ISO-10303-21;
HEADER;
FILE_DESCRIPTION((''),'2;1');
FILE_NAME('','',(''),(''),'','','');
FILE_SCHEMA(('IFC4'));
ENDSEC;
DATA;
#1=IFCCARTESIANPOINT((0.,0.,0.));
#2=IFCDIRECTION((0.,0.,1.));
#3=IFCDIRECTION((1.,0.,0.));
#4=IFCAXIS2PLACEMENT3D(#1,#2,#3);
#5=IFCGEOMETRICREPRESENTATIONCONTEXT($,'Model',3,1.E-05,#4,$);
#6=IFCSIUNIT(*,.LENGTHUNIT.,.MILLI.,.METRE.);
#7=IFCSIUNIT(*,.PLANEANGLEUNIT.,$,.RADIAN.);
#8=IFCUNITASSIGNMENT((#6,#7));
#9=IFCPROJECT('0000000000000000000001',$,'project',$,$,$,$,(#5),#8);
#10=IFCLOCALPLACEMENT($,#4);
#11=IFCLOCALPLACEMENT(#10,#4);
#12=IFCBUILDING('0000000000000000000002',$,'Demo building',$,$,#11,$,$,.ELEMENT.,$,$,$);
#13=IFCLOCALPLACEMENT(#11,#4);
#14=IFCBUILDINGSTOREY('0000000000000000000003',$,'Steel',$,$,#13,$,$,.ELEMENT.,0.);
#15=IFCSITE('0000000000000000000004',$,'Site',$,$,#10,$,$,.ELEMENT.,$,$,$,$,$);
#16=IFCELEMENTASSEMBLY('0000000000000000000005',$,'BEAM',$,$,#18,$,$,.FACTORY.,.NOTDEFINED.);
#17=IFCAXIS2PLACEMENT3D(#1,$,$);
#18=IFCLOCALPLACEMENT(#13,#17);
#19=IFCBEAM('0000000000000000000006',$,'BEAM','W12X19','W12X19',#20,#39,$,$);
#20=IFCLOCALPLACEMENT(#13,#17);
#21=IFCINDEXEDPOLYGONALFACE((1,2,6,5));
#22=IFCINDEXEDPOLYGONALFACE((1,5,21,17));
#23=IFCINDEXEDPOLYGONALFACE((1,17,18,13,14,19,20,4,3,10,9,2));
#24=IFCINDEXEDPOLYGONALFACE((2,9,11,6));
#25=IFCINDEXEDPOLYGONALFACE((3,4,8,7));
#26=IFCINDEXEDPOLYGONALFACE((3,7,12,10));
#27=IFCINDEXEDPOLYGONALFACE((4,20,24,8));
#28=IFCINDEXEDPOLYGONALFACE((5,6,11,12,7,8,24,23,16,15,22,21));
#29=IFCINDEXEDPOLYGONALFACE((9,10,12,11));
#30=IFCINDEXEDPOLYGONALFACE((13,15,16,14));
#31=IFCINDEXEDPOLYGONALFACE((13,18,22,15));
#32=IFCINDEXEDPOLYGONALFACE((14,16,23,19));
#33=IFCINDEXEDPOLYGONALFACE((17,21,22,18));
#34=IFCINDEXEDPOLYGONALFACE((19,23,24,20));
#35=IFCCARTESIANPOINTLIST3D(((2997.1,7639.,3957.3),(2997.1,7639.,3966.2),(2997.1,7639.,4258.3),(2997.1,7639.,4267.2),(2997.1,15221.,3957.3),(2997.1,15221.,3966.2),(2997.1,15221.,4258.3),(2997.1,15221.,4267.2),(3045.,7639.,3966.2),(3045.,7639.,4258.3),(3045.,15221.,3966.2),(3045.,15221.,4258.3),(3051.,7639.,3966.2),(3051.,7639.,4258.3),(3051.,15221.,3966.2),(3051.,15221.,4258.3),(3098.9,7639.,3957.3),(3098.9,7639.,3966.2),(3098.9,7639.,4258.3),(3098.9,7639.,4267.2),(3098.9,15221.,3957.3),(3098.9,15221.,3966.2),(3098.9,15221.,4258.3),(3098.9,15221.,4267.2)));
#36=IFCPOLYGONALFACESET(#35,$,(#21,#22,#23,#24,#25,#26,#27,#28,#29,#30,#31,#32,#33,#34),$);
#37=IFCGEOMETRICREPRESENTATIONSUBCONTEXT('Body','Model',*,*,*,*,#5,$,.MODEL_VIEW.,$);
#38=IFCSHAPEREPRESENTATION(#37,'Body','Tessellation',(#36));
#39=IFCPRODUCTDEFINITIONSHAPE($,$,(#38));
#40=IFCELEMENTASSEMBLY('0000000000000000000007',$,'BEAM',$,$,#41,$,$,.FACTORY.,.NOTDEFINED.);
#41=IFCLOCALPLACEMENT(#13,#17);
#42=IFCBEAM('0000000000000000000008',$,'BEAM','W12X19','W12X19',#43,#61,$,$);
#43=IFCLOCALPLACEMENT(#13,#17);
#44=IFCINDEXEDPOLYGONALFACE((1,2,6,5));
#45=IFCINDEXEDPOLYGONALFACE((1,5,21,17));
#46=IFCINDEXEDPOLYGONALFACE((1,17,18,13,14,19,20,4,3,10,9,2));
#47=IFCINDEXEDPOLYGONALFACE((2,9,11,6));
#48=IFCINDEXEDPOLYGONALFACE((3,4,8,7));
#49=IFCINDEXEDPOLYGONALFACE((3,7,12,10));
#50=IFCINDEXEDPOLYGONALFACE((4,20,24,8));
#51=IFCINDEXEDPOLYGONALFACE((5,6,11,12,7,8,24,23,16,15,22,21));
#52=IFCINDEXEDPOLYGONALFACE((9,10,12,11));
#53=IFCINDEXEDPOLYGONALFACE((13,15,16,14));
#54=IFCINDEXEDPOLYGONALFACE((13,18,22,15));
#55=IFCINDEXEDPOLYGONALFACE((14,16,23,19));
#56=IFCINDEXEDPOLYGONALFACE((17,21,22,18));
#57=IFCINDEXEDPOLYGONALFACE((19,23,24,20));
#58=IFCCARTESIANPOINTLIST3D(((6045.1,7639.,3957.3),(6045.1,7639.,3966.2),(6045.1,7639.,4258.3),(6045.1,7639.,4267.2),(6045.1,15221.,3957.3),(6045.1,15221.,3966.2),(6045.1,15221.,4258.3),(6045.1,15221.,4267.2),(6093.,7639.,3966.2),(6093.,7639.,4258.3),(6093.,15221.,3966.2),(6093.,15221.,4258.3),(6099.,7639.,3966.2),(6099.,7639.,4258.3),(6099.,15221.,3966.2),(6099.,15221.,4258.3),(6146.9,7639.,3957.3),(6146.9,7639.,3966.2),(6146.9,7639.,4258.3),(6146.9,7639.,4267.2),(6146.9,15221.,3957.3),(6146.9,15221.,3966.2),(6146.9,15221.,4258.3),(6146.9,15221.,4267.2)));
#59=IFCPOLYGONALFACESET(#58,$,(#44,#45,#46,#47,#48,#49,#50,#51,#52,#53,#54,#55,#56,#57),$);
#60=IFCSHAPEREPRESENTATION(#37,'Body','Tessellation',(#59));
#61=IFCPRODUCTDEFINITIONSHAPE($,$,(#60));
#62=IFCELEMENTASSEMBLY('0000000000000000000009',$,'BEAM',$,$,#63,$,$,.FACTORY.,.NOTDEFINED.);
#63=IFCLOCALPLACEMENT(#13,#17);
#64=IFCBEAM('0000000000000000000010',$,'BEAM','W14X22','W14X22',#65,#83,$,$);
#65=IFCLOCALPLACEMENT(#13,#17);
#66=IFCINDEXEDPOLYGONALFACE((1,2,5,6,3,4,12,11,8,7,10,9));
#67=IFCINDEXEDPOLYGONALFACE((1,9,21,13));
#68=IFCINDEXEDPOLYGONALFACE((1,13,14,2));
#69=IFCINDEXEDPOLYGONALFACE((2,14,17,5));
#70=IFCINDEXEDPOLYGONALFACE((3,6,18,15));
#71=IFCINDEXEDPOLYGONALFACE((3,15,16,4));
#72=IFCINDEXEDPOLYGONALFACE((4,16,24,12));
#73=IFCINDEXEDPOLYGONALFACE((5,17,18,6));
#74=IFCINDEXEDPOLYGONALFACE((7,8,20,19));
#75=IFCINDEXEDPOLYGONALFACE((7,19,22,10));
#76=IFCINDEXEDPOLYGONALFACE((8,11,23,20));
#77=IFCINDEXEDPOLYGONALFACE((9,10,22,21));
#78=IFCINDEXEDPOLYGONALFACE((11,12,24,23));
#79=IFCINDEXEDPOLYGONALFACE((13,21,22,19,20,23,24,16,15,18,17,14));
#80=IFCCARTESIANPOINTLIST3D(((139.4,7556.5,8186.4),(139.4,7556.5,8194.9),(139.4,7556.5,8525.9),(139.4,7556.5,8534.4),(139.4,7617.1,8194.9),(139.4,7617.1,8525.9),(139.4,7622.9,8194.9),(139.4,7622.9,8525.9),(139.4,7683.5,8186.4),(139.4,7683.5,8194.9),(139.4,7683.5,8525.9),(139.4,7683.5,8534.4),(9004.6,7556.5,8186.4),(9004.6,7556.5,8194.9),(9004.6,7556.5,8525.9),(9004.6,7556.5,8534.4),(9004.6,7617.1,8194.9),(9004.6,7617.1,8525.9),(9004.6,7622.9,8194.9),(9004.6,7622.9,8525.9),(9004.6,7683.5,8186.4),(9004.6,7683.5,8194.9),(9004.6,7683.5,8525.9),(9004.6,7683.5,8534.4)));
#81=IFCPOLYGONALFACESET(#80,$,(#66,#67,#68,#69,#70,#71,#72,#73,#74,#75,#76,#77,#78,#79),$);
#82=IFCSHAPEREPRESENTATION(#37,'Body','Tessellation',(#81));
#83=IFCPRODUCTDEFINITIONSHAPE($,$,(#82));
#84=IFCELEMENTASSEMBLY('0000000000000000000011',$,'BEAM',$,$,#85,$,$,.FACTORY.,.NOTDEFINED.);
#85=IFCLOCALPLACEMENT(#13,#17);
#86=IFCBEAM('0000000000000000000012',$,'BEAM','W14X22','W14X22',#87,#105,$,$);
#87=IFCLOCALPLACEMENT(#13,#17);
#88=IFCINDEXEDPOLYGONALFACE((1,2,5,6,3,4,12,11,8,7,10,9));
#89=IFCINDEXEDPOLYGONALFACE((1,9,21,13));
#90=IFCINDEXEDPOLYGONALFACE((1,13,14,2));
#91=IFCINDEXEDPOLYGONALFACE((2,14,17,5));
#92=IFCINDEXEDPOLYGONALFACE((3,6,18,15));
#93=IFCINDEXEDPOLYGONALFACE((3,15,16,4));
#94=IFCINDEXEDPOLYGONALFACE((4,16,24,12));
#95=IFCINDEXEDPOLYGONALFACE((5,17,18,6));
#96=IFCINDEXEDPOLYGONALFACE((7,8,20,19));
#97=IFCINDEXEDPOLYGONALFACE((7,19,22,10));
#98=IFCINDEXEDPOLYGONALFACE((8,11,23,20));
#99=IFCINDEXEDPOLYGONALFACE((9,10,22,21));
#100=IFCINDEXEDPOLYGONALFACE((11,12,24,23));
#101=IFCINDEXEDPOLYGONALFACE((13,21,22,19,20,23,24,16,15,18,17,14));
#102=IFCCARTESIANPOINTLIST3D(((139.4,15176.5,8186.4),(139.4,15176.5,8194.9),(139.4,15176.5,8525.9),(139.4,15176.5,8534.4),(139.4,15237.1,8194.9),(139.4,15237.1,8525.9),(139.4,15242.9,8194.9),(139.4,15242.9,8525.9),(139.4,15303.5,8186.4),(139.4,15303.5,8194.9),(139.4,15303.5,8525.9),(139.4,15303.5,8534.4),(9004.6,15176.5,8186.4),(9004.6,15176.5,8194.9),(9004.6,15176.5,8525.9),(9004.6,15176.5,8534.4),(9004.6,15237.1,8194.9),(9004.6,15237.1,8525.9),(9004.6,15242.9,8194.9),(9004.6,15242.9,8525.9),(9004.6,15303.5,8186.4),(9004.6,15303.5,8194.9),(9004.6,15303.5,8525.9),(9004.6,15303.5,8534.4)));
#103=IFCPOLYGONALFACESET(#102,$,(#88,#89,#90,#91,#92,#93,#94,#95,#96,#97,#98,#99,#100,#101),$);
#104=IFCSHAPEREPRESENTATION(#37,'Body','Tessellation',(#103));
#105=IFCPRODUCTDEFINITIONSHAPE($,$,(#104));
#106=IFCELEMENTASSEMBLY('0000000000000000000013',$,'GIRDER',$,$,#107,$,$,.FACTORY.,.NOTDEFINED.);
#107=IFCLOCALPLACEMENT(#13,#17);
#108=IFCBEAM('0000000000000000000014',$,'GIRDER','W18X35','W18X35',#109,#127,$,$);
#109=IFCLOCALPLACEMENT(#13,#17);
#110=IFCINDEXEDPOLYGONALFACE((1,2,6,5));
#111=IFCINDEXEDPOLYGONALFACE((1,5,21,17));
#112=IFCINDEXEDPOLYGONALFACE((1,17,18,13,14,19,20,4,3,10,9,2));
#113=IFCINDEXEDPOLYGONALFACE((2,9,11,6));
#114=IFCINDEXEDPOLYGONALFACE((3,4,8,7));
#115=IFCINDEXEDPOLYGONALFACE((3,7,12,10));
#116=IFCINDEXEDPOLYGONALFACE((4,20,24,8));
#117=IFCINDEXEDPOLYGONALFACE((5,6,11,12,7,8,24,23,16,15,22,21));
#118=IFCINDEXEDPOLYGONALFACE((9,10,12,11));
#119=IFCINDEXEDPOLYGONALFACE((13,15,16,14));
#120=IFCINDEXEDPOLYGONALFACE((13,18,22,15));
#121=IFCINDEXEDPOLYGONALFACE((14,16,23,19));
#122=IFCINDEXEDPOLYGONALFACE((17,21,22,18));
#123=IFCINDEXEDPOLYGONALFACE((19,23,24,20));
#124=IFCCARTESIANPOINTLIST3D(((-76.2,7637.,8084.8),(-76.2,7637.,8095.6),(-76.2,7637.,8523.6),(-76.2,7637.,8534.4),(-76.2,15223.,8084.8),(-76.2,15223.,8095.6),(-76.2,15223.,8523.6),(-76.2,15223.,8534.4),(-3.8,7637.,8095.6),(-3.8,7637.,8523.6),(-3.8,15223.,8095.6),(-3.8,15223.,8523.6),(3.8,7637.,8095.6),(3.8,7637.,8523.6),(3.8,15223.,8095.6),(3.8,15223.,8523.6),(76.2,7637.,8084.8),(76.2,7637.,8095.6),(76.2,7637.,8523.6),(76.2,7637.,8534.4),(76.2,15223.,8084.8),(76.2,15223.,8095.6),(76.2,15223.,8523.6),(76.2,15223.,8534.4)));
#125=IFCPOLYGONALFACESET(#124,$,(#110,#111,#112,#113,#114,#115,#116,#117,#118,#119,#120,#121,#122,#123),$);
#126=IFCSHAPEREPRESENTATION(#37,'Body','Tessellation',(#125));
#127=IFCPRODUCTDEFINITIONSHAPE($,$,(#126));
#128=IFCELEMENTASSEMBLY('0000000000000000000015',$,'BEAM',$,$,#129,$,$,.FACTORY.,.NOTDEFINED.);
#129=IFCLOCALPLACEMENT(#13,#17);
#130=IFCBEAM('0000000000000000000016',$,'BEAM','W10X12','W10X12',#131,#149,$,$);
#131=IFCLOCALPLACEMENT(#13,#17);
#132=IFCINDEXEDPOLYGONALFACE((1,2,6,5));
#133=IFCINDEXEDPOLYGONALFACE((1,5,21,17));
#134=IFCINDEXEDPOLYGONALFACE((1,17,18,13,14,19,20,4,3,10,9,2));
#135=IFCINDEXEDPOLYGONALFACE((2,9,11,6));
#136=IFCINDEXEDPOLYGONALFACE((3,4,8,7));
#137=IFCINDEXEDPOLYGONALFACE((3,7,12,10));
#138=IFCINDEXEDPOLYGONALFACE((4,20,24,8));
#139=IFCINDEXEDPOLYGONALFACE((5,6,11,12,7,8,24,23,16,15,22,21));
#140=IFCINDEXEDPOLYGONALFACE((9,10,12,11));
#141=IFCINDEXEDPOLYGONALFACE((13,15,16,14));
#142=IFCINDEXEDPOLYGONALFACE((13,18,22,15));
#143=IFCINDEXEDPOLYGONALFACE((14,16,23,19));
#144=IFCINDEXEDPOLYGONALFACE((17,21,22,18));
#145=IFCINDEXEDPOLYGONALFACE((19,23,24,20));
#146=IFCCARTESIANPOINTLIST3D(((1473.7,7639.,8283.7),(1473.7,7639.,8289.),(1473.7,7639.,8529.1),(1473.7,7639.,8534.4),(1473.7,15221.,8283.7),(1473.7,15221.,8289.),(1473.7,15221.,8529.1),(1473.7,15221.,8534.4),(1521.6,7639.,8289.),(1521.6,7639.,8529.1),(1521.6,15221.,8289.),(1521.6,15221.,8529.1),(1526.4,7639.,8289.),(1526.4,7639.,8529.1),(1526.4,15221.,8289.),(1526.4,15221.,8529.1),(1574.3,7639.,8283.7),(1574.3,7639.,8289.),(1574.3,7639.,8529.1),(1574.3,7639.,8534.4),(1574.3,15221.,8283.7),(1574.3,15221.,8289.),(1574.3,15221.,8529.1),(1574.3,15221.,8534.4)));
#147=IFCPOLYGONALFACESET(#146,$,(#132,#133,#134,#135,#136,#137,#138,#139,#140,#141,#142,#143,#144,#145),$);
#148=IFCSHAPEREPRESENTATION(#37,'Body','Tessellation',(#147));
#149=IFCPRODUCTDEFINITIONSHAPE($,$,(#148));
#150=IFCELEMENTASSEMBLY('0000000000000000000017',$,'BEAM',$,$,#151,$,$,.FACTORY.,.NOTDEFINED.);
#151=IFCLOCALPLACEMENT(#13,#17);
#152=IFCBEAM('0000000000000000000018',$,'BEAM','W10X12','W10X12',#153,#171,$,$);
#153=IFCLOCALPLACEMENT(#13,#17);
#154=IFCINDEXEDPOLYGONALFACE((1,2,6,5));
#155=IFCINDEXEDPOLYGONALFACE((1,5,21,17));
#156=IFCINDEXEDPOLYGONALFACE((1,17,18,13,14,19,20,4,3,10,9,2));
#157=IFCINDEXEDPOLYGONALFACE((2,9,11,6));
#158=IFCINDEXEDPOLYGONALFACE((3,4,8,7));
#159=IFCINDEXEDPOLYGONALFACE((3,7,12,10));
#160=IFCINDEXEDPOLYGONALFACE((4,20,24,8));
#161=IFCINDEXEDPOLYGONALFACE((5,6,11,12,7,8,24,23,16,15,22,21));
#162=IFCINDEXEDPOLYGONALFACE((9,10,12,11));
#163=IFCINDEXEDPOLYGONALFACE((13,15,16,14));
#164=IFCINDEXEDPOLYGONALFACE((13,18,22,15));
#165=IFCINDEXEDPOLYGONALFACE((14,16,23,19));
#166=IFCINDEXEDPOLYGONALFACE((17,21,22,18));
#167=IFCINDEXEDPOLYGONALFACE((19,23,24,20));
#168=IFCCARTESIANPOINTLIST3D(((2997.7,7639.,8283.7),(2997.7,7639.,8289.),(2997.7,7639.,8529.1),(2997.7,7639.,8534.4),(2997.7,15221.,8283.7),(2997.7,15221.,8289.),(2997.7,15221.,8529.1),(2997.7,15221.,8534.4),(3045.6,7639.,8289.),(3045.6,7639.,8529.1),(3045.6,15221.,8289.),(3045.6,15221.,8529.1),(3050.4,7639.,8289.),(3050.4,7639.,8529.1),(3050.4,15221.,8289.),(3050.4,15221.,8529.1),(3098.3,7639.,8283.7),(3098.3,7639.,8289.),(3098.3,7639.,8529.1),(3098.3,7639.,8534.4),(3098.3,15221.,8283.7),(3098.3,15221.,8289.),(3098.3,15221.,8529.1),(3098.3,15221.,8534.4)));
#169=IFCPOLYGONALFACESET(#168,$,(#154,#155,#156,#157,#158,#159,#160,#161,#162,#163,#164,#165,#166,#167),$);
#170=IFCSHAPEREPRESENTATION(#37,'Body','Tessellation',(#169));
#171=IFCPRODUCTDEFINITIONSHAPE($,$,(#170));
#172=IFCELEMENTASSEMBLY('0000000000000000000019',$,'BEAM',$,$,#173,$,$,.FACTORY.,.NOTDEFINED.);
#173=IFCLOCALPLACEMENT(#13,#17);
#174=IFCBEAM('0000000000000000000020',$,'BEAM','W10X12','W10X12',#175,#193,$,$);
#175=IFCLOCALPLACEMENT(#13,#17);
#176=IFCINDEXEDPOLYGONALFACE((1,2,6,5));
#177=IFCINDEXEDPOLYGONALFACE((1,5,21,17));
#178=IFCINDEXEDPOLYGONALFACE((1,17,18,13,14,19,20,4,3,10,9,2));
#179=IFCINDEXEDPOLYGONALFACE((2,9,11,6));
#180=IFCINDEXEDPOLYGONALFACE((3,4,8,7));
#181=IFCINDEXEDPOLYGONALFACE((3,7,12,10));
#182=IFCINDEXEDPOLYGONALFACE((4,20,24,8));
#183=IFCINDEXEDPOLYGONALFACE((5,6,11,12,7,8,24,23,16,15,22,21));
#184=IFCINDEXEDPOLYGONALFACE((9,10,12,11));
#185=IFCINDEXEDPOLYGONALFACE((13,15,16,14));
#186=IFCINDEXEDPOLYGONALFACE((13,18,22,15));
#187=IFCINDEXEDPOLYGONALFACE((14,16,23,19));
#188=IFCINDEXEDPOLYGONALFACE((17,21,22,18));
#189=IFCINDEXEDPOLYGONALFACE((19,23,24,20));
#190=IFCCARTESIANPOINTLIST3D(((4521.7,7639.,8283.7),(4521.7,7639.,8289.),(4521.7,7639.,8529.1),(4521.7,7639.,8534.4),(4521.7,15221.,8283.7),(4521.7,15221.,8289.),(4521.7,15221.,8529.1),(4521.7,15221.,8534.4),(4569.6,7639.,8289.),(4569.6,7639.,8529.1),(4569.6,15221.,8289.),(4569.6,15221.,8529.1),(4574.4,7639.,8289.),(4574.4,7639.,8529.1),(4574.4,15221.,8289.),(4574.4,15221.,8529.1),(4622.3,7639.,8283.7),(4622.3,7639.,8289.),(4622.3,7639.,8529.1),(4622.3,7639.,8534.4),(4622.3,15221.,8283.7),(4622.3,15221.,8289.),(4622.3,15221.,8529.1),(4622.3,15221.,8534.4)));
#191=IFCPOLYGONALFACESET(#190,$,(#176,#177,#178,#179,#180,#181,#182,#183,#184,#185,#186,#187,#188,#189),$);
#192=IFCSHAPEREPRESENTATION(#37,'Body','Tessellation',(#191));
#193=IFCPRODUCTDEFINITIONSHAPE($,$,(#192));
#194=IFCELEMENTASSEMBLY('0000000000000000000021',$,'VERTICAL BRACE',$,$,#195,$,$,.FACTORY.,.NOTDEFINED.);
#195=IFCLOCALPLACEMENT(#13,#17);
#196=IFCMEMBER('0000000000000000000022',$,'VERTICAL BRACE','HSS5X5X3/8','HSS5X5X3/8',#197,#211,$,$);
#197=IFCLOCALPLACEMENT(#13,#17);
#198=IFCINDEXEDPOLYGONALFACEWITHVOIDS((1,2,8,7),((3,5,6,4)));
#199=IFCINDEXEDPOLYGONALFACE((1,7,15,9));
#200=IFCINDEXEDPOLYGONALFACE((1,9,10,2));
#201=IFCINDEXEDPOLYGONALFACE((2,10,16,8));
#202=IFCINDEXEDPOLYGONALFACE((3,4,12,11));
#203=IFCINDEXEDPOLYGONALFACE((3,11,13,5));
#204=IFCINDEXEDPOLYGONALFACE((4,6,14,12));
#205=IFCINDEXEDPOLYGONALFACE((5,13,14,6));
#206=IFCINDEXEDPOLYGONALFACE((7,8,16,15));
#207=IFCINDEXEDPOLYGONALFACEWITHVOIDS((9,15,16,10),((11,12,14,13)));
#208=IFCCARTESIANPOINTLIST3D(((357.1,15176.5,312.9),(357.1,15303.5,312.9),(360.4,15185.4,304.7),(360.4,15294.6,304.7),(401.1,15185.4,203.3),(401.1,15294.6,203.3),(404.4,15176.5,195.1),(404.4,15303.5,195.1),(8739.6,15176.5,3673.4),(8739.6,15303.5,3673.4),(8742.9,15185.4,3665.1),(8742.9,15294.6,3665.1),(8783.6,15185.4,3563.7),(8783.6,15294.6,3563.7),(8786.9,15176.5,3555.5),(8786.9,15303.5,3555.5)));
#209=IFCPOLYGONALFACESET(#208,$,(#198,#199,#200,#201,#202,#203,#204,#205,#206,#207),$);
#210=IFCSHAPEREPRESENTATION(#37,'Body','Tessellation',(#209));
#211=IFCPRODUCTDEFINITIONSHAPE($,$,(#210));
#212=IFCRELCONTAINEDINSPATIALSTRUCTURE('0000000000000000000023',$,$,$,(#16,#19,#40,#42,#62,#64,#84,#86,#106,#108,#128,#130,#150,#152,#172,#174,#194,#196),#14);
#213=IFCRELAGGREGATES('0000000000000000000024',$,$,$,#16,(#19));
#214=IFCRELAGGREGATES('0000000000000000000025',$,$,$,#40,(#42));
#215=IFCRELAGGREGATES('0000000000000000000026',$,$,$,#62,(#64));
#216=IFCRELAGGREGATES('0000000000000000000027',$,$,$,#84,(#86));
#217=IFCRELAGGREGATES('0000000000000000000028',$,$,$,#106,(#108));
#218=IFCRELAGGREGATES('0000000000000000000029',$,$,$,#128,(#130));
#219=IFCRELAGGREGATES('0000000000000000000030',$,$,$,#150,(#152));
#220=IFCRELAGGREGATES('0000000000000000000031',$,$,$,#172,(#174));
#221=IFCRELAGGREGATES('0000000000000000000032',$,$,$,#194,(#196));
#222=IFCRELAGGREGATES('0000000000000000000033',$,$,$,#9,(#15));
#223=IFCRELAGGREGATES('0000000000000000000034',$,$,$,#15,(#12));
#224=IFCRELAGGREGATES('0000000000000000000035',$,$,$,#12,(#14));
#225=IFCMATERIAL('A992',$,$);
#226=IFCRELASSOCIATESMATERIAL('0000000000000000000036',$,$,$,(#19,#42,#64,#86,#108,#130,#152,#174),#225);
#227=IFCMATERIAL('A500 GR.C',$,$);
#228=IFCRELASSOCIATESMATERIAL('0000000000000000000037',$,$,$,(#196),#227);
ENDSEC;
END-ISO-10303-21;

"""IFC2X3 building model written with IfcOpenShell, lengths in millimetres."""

from ifc_helpers import new_model, si_unit, frame, origin, origin_with_axes, origin_2d, place, context, subcontext, project, spatial, hollow_rectangle, i_section, extrude, material, element, aggregate, save


model = new_model("IFC2X3")

# Units and contexts
model_context = context("Model", 3, precision=1e-05, world=origin_with_axes())
body_context = subcontext(model_context, "Body", "Model", "MODEL_VIEW")
ifc_project = project(units=[si_unit("LENGTHUNIT", "METRE", prefix="MILLI"), si_unit("PLANEANGLEUNIT", "RADIAN")], contexts=[model_context])

# Site, building, storey
site_placement = place(None, origin_with_axes())
site = spatial("IfcSite", under=ifc_project, at=site_placement, Name="Site", CompositionType="ELEMENT")
building_placement = place(site_placement, origin_with_axes())
building = spatial("IfcBuilding", under=site, at=building_placement, Name="Demo building", CompositionType="ELEMENT")
placement = place(building_placement, origin_with_axes())
storey = spatial("IfcBuildingStorey", under=building, at=placement, Name="Steel", CompositionType="ELEMENT", Elevation=0.0)

# Shared definitions
ifc_material_1 = material(Name="A992")

# Element assemblies, beams
assembly_1 = element("IfcElementAssembly", 1, at=placement, inside=storey, Name="BEAM", AssemblyPlace="FACTORY", PredefinedType="NOTDEFINED")
beam_1_placement = place(placement, frame((3048.0, 7639.1, 4112.3), z_axis=(0.0, 1.0, 0.0), x_axis=(-1.0, 0.0, 0.0)))
beam_1 = element("IfcBeam", 2, at=beam_1_placement, inside=storey, material=ifc_material_1, Name="BEAM", Description="W12X19", ObjectType="W12X19", context=body_context, shape_type="SweptSolid", body=[
    extrude(i_section(OverallWidth=101.9, OverallDepth=309.9, WebThickness=6.0, FlangeThickness=8.9, at=origin_2d()), origin(), (0.0, 0.0, 1.0), 7581.9),
])
aggregate(assembly_1, [beam_1])
assembly_2 = element("IfcElementAssembly", 3, at=placement, inside=storey, Name="BEAM", AssemblyPlace="FACTORY", PredefinedType="NOTDEFINED")
beam_2_placement = place(placement, frame((6096.0, 7639.1, 4112.3), z_axis=(0.0, 1.0, 0.0), x_axis=(-1.0, 0.0, 0.0)))
beam_2 = element("IfcBeam", 4, at=beam_2_placement, inside=storey, material=ifc_material_1, Name="BEAM", Description="W12X19", ObjectType="W12X19", context=body_context, shape_type="SweptSolid", body=[
    extrude(i_section(OverallWidth=101.9, OverallDepth=309.9, WebThickness=6.0, FlangeThickness=8.9, at=origin_2d()), origin(), (0.0, 0.0, 1.0), 7581.9),
])
aggregate(assembly_2, [beam_2])
assembly_3 = element("IfcElementAssembly", 5, at=placement, inside=storey, Name="BEAM", AssemblyPlace="FACTORY", PredefinedType="NOTDEFINED")
beam_3_placement = place(placement, frame((139.4, 7620.0, 8360.4), z_axis=(1.0, 0.0, 0.0), x_axis=(0.0, 1.0, 0.0)))
beam_3 = element("IfcBeam", 6, at=beam_3_placement, inside=storey, material=ifc_material_1, Name="BEAM", Description="W14X22", ObjectType="W14X22", context=body_context, shape_type="SweptSolid", body=[
    extrude(i_section(OverallWidth=127.0, OverallDepth=348.0, WebThickness=5.8, FlangeThickness=8.5, at=origin_2d()), origin(), (0.0, 0.0, 1.0), 8865.1),
])
aggregate(assembly_3, [beam_3])
assembly_4 = element("IfcElementAssembly", 7, at=placement, inside=storey, Name="BEAM", AssemblyPlace="FACTORY", PredefinedType="NOTDEFINED")
beam_4_placement = place(placement, frame((139.4, 15240.0, 8360.4), z_axis=(1.0, 0.0, 0.0), x_axis=(0.0, 1.0, 0.0)))
beam_4 = element("IfcBeam", 8, at=beam_4_placement, inside=storey, material=ifc_material_1, Name="BEAM", Description="W14X22", ObjectType="W14X22", context=body_context, shape_type="SweptSolid", body=[
    extrude(i_section(OverallWidth=127.0, OverallDepth=348.0, WebThickness=5.8, FlangeThickness=8.5, at=origin_2d()), origin(), (0.0, 0.0, 1.0), 8865.1),
])
aggregate(assembly_4, [beam_4])
assembly_5 = element("IfcElementAssembly", 9, at=placement, inside=storey, Name="GIRDER", AssemblyPlace="FACTORY", PredefinedType="NOTDEFINED")
beam_5_placement = place(placement, frame((0.0, 7637.0, 8309.6), z_axis=(0.0, 1.0, 0.0), x_axis=(-1.0, 0.0, 0.0)))
beam_5 = element("IfcBeam", 10, at=beam_5_placement, inside=storey, material=ifc_material_1, Name="GIRDER", Description="W18X35", ObjectType="W18X35", context=body_context, shape_type="SweptSolid", body=[
    extrude(i_section(OverallWidth=152.4, OverallDepth=449.6, WebThickness=7.6, FlangeThickness=10.8, at=origin_2d()), origin(), (0.0, 0.0, 1.0), 7586.0),
])
aggregate(assembly_5, [beam_5])
assembly_6 = element("IfcElementAssembly", 11, at=placement, inside=storey, Name="BEAM", AssemblyPlace="FACTORY", PredefinedType="NOTDEFINED")
beam_6_placement = place(placement, frame((1524.0, 7639.1, 8409.1), z_axis=(0.0, 1.0, 0.0), x_axis=(-1.0, 0.0, 0.0)))
beam_6 = element("IfcBeam", 12, at=beam_6_placement, inside=storey, material=ifc_material_1, Name="BEAM", Description="W10X12", ObjectType="W10X12", context=body_context, shape_type="SweptSolid", body=[
    extrude(i_section(OverallWidth=100.6, OverallDepth=250.7, WebThickness=4.8, FlangeThickness=5.3, at=origin_2d()), origin(), (0.0, 0.0, 1.0), 7581.9),
])
aggregate(assembly_6, [beam_6])
assembly_7 = element("IfcElementAssembly", 13, at=placement, inside=storey, Name="BEAM", AssemblyPlace="FACTORY", PredefinedType="NOTDEFINED")
beam_7_placement = place(placement, frame((3048.0, 7639.1, 8409.1), z_axis=(0.0, 1.0, 0.0), x_axis=(-1.0, 0.0, 0.0)))
beam_7 = element("IfcBeam", 14, at=beam_7_placement, inside=storey, material=ifc_material_1, Name="BEAM", Description="W10X12", ObjectType="W10X12", context=body_context, shape_type="SweptSolid", body=[
    extrude(i_section(OverallWidth=100.6, OverallDepth=250.7, WebThickness=4.8, FlangeThickness=5.3, at=origin_2d()), origin(), (0.0, 0.0, 1.0), 7581.9),
])
aggregate(assembly_7, [beam_7])
assembly_8 = element("IfcElementAssembly", 15, at=placement, inside=storey, Name="BEAM", AssemblyPlace="FACTORY", PredefinedType="NOTDEFINED")
beam_8_placement = place(placement, frame((4572.0, 7639.1, 8409.1), z_axis=(0.0, 1.0, 0.0), x_axis=(-1.0, 0.0, 0.0)))
beam_8 = element("IfcBeam", 16, at=beam_8_placement, inside=storey, material=ifc_material_1, Name="BEAM", Description="W10X12", ObjectType="W10X12", context=body_context, shape_type="SweptSolid", body=[
    extrude(i_section(OverallWidth=100.6, OverallDepth=250.7, WebThickness=4.8, FlangeThickness=5.3, at=origin_2d()), origin(), (0.0, 0.0, 1.0), 7581.9),
])
aggregate(assembly_8, [beam_8])

# Element assembly, member
assembly_9 = element("IfcElementAssembly", 17, at=placement, inside=storey, Name="VERTICAL BRACE", AssemblyPlace="FACTORY", PredefinedType="NOTDEFINED")
ifc_material_2 = material(Name="A500 GR.C")
member_1_placement = place(placement, frame((380.7, 15240.0, 254.0), z_axis=(0.9282, 0.0, 0.3721), x_axis=(0.0, 1.0, 0.0)))
member_1 = element("IfcMember", 18, at=member_1_placement, inside=storey, material=ifc_material_2, Name="VERTICAL BRACE", Description="HSS5X5X3/8", ObjectType="HSS5X5X3/8", context=body_context, shape_type="SweptSolid", body=[
    extrude(hollow_rectangle(XDim=127.0, YDim=127.0, WallThickness=8.9, at=origin_2d()), origin(), (0.0, 0.0, 1.0), 9031.0),
])
aggregate(assembly_9, [member_1])

save(model, "model.ifc")
